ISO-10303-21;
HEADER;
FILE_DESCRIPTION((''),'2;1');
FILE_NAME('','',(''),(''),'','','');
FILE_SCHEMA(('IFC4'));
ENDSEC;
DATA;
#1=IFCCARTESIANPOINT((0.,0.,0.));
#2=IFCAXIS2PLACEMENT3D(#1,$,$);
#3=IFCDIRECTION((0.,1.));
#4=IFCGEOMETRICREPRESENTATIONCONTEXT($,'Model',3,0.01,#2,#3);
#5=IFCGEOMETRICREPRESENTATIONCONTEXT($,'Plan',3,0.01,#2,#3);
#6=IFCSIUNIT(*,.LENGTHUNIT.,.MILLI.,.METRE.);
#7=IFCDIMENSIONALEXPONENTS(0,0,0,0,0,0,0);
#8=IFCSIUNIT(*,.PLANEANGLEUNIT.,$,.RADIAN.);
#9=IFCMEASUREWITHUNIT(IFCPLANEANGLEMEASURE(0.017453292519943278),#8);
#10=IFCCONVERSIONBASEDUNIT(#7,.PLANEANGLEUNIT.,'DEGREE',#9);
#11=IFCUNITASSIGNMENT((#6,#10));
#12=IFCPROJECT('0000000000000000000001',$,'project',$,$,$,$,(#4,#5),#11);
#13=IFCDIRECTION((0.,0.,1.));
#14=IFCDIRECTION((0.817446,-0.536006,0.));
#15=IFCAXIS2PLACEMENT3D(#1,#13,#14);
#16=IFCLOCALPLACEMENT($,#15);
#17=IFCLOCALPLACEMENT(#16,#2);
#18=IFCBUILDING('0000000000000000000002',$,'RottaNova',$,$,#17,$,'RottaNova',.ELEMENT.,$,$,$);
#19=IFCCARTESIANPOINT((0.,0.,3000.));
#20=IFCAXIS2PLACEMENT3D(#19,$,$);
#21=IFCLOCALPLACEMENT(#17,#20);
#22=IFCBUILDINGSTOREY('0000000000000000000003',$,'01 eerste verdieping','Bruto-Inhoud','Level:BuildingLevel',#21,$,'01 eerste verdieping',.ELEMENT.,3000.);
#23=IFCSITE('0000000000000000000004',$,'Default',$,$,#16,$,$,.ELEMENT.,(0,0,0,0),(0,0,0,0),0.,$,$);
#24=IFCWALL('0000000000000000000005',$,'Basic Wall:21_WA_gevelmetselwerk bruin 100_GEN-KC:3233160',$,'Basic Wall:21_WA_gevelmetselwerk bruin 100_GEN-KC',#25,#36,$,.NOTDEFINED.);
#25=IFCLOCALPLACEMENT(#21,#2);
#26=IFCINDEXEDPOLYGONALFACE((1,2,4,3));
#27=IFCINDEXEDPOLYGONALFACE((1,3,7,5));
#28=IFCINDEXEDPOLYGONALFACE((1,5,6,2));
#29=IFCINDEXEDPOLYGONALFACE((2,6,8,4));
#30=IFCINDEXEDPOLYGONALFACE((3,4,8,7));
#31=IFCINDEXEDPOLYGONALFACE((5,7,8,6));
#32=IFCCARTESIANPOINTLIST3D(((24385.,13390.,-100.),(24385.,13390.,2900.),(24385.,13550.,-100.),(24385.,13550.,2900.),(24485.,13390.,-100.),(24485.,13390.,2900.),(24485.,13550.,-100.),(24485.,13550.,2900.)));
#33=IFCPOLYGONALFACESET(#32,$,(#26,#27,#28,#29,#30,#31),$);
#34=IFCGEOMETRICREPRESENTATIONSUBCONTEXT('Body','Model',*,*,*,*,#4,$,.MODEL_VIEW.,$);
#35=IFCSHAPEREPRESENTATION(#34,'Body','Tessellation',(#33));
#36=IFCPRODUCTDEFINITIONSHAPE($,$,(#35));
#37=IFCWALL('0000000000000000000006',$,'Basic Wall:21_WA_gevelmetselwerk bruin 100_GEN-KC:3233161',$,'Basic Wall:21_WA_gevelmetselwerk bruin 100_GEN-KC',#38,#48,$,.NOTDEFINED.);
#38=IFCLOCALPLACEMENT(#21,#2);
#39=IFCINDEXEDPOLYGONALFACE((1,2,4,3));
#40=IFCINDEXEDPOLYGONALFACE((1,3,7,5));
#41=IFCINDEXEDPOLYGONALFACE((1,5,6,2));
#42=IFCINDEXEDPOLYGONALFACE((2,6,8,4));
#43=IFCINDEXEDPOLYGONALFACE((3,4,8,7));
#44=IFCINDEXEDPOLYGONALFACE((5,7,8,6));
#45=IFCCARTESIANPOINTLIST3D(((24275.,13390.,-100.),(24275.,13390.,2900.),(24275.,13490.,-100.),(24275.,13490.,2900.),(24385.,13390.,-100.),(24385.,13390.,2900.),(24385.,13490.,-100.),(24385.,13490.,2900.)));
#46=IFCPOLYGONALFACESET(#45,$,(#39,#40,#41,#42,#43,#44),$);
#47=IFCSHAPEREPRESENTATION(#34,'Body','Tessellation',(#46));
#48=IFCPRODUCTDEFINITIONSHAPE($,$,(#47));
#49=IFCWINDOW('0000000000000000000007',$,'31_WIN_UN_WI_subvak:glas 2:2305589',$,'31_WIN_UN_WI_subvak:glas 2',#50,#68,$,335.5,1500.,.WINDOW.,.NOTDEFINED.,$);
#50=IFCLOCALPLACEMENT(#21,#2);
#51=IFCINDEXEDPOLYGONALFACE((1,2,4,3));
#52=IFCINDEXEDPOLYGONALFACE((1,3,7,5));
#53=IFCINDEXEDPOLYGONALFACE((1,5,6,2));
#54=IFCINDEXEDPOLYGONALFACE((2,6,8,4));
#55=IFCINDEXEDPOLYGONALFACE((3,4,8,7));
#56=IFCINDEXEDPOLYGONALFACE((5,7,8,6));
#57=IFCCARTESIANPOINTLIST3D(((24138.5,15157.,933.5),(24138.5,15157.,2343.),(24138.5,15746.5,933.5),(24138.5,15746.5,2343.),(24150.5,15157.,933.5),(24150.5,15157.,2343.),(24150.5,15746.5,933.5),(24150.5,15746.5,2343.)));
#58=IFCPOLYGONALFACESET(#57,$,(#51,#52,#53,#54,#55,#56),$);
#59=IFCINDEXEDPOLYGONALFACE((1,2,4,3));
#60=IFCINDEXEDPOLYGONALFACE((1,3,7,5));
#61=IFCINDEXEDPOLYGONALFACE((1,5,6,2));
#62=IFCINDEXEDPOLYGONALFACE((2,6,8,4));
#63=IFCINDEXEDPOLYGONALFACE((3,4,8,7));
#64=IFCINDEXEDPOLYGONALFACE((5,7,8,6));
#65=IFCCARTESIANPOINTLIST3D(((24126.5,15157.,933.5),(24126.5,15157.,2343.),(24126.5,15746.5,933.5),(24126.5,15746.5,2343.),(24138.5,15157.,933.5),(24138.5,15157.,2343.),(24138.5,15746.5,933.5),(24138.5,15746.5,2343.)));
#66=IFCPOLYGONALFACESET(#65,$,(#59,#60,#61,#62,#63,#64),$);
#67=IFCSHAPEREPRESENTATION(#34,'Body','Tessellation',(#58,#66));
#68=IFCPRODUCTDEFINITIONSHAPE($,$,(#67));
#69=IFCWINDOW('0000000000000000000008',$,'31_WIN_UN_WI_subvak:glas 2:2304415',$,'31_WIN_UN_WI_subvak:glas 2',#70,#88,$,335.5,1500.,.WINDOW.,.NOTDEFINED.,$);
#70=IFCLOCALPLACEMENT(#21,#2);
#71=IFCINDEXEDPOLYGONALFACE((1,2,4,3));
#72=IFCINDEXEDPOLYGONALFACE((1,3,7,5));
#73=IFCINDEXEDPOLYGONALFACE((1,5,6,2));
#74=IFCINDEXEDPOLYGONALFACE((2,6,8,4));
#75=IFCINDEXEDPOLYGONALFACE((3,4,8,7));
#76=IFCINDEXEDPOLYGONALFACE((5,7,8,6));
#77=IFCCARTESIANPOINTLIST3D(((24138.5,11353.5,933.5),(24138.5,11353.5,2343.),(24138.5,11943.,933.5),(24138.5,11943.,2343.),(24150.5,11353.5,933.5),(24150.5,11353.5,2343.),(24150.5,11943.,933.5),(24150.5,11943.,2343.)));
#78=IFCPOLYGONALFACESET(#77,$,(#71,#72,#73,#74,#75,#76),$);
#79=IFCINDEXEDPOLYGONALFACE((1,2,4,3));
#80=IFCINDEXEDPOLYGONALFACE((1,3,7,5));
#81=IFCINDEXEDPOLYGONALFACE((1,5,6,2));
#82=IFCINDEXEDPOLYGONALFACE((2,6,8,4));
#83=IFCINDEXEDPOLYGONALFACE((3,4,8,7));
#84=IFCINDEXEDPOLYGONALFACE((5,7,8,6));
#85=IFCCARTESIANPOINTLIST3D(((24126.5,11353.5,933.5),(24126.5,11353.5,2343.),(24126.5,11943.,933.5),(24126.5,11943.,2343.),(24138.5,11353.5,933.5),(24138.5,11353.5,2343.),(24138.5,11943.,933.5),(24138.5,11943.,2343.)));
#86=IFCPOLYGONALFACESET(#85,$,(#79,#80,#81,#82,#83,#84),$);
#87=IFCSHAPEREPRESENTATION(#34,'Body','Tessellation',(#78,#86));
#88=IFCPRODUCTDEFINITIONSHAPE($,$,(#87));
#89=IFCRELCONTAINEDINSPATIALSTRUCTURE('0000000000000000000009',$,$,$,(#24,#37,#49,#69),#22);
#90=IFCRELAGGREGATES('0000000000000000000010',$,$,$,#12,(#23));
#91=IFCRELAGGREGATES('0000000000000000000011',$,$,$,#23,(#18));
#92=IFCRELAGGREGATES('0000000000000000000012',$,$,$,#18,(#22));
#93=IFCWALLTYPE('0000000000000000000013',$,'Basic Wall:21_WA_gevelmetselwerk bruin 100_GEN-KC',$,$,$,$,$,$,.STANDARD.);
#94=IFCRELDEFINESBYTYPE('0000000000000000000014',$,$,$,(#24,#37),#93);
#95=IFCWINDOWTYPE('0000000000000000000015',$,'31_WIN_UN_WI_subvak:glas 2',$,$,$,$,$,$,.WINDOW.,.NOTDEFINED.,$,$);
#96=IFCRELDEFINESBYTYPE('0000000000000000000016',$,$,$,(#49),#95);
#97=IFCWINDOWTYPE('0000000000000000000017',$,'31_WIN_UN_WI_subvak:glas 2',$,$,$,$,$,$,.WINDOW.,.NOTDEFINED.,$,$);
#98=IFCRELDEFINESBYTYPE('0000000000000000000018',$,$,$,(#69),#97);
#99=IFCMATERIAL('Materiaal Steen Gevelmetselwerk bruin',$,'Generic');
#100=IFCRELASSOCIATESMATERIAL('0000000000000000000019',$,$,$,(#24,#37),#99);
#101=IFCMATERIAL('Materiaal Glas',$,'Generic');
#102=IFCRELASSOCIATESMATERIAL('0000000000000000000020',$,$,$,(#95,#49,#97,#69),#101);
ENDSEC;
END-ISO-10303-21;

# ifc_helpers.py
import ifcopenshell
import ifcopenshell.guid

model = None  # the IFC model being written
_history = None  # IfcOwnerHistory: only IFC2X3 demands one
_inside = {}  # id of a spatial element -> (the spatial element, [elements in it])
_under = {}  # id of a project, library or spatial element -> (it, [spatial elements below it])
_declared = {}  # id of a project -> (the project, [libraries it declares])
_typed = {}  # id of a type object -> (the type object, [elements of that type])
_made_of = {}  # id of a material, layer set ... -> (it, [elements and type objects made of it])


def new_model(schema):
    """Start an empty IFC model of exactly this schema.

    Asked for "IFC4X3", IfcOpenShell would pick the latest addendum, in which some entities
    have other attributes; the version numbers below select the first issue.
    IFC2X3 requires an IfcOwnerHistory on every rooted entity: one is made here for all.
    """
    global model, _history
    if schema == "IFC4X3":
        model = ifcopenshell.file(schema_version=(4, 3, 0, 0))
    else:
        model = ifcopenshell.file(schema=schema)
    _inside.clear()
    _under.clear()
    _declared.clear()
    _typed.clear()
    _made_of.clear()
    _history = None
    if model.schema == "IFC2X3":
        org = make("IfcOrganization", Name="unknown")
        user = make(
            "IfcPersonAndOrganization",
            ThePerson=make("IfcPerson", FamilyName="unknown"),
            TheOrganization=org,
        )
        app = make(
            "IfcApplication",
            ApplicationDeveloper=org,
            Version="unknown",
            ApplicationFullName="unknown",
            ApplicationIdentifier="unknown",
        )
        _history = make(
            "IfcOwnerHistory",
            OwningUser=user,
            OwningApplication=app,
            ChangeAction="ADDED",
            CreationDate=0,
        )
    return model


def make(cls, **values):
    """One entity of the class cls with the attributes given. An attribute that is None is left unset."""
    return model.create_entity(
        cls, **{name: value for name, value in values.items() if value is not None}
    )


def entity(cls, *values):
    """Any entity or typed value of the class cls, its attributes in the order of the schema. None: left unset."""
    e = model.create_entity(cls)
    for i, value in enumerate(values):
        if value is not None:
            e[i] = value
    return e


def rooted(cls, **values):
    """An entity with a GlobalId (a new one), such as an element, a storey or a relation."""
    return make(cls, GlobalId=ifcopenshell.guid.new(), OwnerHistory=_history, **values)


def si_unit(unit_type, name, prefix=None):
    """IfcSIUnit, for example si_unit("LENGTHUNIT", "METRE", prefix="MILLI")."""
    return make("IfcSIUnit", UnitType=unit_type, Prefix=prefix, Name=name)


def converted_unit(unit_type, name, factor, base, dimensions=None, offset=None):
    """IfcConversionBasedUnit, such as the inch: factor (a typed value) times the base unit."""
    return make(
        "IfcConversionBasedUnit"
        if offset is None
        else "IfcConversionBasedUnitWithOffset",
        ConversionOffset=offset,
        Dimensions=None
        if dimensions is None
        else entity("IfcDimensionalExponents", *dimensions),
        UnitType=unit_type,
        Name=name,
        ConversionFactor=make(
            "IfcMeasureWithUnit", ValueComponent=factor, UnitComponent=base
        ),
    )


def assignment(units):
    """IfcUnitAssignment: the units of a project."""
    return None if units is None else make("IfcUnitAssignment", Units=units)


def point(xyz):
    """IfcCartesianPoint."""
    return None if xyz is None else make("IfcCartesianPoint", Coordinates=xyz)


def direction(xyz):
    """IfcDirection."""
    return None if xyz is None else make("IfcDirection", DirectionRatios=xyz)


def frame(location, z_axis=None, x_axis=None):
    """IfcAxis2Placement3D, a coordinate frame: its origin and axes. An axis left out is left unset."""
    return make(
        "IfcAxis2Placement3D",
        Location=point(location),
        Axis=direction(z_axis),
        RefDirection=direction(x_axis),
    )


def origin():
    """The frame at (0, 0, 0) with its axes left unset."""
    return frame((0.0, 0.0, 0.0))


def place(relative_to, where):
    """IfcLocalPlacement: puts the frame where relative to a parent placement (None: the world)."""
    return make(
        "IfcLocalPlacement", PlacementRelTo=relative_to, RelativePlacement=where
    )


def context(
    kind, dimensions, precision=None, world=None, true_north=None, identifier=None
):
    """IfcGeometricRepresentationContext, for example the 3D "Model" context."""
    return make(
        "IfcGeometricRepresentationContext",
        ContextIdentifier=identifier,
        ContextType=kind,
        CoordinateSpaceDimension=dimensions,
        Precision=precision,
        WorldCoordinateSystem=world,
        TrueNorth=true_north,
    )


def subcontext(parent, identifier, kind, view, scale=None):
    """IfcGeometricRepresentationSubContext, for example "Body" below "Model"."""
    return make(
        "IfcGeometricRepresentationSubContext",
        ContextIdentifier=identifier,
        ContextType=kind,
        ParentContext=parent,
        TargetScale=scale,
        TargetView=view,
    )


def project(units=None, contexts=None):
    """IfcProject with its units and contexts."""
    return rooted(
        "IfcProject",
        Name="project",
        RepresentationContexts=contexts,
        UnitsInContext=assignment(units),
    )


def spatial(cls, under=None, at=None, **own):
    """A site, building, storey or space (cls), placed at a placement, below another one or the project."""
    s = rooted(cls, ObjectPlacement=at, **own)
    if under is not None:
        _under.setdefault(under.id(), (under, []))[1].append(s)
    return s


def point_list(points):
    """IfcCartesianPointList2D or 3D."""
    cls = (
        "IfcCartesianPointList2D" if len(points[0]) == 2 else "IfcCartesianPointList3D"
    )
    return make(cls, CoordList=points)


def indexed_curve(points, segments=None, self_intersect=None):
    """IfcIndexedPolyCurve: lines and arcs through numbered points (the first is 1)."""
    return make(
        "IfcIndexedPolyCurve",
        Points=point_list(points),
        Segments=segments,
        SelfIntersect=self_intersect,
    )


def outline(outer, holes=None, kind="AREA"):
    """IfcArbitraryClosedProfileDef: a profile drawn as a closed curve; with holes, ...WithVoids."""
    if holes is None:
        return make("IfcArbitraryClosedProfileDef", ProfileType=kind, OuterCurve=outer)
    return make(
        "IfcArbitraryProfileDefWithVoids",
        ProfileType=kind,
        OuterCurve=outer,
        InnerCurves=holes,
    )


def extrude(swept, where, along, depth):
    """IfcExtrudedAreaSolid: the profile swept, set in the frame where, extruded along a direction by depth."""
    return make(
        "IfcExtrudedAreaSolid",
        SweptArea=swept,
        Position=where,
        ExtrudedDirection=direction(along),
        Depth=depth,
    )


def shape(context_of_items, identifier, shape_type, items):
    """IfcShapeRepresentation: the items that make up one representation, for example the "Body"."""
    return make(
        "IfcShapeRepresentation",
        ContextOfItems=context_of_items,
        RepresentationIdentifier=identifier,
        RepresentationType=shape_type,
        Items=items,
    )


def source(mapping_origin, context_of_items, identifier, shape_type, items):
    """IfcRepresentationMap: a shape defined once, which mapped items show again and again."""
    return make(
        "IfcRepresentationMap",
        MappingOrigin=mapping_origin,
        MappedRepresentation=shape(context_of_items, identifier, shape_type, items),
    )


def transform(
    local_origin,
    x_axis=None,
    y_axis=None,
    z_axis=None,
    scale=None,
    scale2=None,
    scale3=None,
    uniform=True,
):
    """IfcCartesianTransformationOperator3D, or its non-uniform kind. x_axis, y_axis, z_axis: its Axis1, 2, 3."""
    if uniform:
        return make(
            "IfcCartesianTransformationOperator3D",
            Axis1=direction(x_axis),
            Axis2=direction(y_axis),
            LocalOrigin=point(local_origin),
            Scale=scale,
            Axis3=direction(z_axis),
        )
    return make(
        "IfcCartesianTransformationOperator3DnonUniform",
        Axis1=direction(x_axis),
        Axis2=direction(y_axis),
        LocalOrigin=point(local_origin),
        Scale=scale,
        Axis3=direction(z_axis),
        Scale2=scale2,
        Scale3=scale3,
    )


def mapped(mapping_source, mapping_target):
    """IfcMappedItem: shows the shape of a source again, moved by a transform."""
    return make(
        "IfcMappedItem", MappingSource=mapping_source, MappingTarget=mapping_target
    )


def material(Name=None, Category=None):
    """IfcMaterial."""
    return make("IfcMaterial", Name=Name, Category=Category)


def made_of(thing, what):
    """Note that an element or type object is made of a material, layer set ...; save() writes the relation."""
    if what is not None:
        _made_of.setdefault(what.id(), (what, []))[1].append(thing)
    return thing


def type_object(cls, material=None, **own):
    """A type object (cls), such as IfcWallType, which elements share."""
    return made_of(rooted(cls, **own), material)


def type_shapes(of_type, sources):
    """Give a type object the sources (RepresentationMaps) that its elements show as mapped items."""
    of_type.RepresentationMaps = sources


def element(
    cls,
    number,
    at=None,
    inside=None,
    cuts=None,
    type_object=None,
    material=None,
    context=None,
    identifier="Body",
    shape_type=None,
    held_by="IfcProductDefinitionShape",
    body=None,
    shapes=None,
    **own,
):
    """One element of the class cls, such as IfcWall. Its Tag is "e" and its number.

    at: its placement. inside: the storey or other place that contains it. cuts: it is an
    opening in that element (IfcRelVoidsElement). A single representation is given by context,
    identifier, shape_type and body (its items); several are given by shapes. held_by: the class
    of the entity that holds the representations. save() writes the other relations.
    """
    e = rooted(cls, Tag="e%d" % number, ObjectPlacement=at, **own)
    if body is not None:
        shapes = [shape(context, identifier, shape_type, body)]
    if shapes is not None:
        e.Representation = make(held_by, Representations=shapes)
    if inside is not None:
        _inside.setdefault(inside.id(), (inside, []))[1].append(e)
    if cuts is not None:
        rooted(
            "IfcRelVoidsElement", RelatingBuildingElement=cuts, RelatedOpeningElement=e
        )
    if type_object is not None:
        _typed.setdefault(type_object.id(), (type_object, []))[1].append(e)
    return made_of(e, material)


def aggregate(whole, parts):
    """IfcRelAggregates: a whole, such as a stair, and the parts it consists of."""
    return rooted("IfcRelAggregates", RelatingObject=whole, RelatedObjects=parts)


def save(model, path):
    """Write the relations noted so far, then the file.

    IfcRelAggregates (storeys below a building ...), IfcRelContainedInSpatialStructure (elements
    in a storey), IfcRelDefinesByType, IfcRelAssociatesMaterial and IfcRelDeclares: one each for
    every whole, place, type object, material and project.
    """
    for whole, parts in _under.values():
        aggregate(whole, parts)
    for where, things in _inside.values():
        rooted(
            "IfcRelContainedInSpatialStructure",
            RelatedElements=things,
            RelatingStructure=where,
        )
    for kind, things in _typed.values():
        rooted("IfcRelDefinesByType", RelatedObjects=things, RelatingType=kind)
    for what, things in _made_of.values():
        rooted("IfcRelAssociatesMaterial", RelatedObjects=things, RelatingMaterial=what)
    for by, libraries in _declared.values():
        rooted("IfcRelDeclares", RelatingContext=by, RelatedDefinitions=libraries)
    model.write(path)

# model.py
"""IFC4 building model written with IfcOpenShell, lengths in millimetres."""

from ifc_helpers import new_model, entity, si_unit, converted_unit, direction, frame, origin, place, context, subcontext, project, spatial, indexed_curve, outline, extrude, source, transform, mapped, material, type_object, type_shapes, element, save


model = new_model("IFC4")

# Units and contexts
model_context = context("Model", 3, precision=0.01, world=origin(), true_north=direction((0.0, 1.0)))
plan_context = context("Plan", 3, precision=0.01, world=origin(), true_north=direction((0.0, 1.0)))
body_context = subcontext(model_context, "Body", "Model", "MODEL_VIEW")
ifc_project = project(units=[si_unit("LENGTHUNIT", "METRE", prefix="MILLI"), converted_unit("PLANEANGLEUNIT", "DEGREE", entity("IfcPlaneAngleMeasure", 0.017453292519943278), si_unit("PLANEANGLEUNIT", "RADIAN"), dimensions=[0, 0, 0, 0, 0, 0, 0])], contexts=[model_context, plan_context])

# Site, building, storey
site_placement = place(None, frame((0.0, 0.0, 0.0), z_axis=(0.0, 0.0, 1.0), x_axis=(0.817446, -0.536006, 0.0)))
site = spatial("IfcSite", under=ifc_project, at=site_placement, Name="Default", CompositionType="ELEMENT", RefLatitude=(0, 0, 0, 0), RefLongitude=(0, 0, 0, 0), RefElevation=0.0)
building_placement = place(site_placement, origin())
building = spatial("IfcBuilding", under=site, at=building_placement, Name="RottaNova", LongName="RottaNova", CompositionType="ELEMENT")
storey_placement = place(building_placement, frame((0.0, 0.0, 3000.0)))
storey = spatial("IfcBuildingStorey", under=building, at=storey_placement, Name="01 eerste verdieping", Description="Bruto-Inhoud", ObjectType="Level:BuildingLevel", LongName="01 eerste verdieping", CompositionType="ELEMENT", Elevation=3000.0)

# Shared definitions
ifc_material_1 = material(Name="Materiaal Glas", Category="Generic")

# Walls
ifc_material_2 = material(Name="Materiaal Steen Gevelmetselwerk bruin", Category="Generic")
wall_type_1 = type_object("IfcWallType", Name="Basic Wall:21_WA_gevelmetselwerk bruin 100_GEN-KC", PredefinedType="STANDARD")
wall_1_placement = place(storey_placement, frame((24435.0, 13390.0, -100.0), z_axis=(0.0, 0.0, 1.0), x_axis=(0.0, 1.0, 0.0)))
element("IfcWall", 1, at=wall_1_placement, inside=storey, type_object=wall_type_1, material=ifc_material_2, Name="Basic Wall:21_WA_gevelmetselwerk bruin 100_GEN-KC:3233160", ObjectType="Basic Wall:21_WA_gevelmetselwerk bruin 100_GEN-KC", PredefinedType="NOTDEFINED", context=body_context, shape_type="SweptSolid", body=[
    extrude(outline(indexed_curve([(160.0, 50.0), (0.0, 50.0), (0.0, -50.0), (160.0, -50.0), (160.0, 50.0)], self_intersect=False)), origin(), (0.0, 0.0, 1.0), 3000.0),
])
wall_2_placement = place(storey_placement, frame((24275.0, 13440.0, -100.0)))
element("IfcWall", 2, at=wall_2_placement, inside=storey, type_object=wall_type_1, material=ifc_material_2, Name="Basic Wall:21_WA_gevelmetselwerk bruin 100_GEN-KC:3233161", ObjectType="Basic Wall:21_WA_gevelmetselwerk bruin 100_GEN-KC", PredefinedType="NOTDEFINED", context=body_context, shape_type="SweptSolid", body=[
    extrude(outline(indexed_curve([(110.0, 50.0), (0.0, 50.0), (0.0, -50.0), (110.0, -50.0), (110.0, 50.0)], self_intersect=False)), origin(), (0.0, 0.0, 1.0), 3000.0),
])

# Windows
window_type_1 = type_object("IfcWindowType", Name="31_WIN_UN_WI_subvak:glas 2", PartitioningType="NOTDEFINED", PredefinedType="WINDOW", material=ifc_material_1)
shared_shape_1 = source(origin(), body_context, "Body", "SweptSolid", [
    extrude(outline(indexed_curve([(-6.0, -294.7), (6.0, -294.7), (6.0, 294.7), (-6.0, 294.7), (-6.0, -294.7)], self_intersect=False)), frame((0.0, 6.0, 0.0), z_axis=(0.0, 0.0, 1.0), x_axis=(0.0, -1.0, 0.0)), (0.0, 0.0, 1.0), 1409.5),
    extrude(outline(indexed_curve([(-6.0, -294.8), (6.0, -294.8), (6.0, 294.8), (-6.0, 294.8), (-6.0, -294.8)], self_intersect=False)), frame((0.0, -6.0, 0.0), z_axis=(0.0, 0.0, 1.0), x_axis=(0.0, -1.0, 0.0)), (0.0, 0.0, 1.0), 1409.5),
])
type_shapes(window_type_1, [shared_shape_1])
window_1_placement = place(storey_placement, frame((24138.5, 15451.8, 933.5), z_axis=(0.0, 0.0, 1.0), x_axis=(0.0, -1.0, 0.0)))
element("IfcWindow", 3, at=window_1_placement, inside=storey, type_object=window_type_1, material=ifc_material_1, Name="31_WIN_UN_WI_subvak:glas 2:2305589", ObjectType="31_WIN_UN_WI_subvak:glas 2", OverallHeight=335.5, OverallWidth=1500.0, PartitioningType="NOTDEFINED", PredefinedType="WINDOW", context=body_context, shape_type="MappedRepresentation", body=[
    mapped(shared_shape_1, transform((0.0, 0.0, 0.0), scale=1.0)),
])
window_type_2 = type_object("IfcWindowType", Name="31_WIN_UN_WI_subvak:glas 2", PartitioningType="NOTDEFINED", PredefinedType="WINDOW", material=ifc_material_1)
shared_shape_2 = source(origin(), body_context, "Body", "SweptSolid", [
    extrude(outline(indexed_curve([(-294.7, -6.0), (294.7, -6.0), (294.7, 6.0), (-294.7, 6.0), (-294.7, -6.0)], self_intersect=False)), frame((0.0, -6.0, 0.0)), (0.0, 0.0, 1.0), 1409.5),
    extrude(outline(indexed_curve([(-294.8, -6.0), (294.8, -6.0), (294.8, 6.0), (-294.8, 6.0), (-294.8, -6.0)], self_intersect=False)), frame((0.0, 6.0, 0.0)), (0.0, 0.0, 1.0), 1409.5),
])
type_shapes(window_type_2, [shared_shape_2])
window_2_placement = place(storey_placement, frame((24138.5, 11648.2, 933.5), z_axis=(0.0, 0.0, 1.0), x_axis=(0.0, 1.0, 0.0)))
element("IfcWindow", 4, at=window_2_placement, inside=storey, type_object=window_type_2, material=ifc_material_1, Name="31_WIN_UN_WI_subvak:glas 2:2304415", ObjectType="31_WIN_UN_WI_subvak:glas 2", OverallHeight=335.5, OverallWidth=1500.0, PartitioningType="NOTDEFINED", PredefinedType="WINDOW", context=body_context, shape_type="MappedRepresentation", body=[
    mapped(shared_shape_2, transform((0.0, 0.0, 0.0), scale=1.0)),
])

save(model, "model.ifc")
